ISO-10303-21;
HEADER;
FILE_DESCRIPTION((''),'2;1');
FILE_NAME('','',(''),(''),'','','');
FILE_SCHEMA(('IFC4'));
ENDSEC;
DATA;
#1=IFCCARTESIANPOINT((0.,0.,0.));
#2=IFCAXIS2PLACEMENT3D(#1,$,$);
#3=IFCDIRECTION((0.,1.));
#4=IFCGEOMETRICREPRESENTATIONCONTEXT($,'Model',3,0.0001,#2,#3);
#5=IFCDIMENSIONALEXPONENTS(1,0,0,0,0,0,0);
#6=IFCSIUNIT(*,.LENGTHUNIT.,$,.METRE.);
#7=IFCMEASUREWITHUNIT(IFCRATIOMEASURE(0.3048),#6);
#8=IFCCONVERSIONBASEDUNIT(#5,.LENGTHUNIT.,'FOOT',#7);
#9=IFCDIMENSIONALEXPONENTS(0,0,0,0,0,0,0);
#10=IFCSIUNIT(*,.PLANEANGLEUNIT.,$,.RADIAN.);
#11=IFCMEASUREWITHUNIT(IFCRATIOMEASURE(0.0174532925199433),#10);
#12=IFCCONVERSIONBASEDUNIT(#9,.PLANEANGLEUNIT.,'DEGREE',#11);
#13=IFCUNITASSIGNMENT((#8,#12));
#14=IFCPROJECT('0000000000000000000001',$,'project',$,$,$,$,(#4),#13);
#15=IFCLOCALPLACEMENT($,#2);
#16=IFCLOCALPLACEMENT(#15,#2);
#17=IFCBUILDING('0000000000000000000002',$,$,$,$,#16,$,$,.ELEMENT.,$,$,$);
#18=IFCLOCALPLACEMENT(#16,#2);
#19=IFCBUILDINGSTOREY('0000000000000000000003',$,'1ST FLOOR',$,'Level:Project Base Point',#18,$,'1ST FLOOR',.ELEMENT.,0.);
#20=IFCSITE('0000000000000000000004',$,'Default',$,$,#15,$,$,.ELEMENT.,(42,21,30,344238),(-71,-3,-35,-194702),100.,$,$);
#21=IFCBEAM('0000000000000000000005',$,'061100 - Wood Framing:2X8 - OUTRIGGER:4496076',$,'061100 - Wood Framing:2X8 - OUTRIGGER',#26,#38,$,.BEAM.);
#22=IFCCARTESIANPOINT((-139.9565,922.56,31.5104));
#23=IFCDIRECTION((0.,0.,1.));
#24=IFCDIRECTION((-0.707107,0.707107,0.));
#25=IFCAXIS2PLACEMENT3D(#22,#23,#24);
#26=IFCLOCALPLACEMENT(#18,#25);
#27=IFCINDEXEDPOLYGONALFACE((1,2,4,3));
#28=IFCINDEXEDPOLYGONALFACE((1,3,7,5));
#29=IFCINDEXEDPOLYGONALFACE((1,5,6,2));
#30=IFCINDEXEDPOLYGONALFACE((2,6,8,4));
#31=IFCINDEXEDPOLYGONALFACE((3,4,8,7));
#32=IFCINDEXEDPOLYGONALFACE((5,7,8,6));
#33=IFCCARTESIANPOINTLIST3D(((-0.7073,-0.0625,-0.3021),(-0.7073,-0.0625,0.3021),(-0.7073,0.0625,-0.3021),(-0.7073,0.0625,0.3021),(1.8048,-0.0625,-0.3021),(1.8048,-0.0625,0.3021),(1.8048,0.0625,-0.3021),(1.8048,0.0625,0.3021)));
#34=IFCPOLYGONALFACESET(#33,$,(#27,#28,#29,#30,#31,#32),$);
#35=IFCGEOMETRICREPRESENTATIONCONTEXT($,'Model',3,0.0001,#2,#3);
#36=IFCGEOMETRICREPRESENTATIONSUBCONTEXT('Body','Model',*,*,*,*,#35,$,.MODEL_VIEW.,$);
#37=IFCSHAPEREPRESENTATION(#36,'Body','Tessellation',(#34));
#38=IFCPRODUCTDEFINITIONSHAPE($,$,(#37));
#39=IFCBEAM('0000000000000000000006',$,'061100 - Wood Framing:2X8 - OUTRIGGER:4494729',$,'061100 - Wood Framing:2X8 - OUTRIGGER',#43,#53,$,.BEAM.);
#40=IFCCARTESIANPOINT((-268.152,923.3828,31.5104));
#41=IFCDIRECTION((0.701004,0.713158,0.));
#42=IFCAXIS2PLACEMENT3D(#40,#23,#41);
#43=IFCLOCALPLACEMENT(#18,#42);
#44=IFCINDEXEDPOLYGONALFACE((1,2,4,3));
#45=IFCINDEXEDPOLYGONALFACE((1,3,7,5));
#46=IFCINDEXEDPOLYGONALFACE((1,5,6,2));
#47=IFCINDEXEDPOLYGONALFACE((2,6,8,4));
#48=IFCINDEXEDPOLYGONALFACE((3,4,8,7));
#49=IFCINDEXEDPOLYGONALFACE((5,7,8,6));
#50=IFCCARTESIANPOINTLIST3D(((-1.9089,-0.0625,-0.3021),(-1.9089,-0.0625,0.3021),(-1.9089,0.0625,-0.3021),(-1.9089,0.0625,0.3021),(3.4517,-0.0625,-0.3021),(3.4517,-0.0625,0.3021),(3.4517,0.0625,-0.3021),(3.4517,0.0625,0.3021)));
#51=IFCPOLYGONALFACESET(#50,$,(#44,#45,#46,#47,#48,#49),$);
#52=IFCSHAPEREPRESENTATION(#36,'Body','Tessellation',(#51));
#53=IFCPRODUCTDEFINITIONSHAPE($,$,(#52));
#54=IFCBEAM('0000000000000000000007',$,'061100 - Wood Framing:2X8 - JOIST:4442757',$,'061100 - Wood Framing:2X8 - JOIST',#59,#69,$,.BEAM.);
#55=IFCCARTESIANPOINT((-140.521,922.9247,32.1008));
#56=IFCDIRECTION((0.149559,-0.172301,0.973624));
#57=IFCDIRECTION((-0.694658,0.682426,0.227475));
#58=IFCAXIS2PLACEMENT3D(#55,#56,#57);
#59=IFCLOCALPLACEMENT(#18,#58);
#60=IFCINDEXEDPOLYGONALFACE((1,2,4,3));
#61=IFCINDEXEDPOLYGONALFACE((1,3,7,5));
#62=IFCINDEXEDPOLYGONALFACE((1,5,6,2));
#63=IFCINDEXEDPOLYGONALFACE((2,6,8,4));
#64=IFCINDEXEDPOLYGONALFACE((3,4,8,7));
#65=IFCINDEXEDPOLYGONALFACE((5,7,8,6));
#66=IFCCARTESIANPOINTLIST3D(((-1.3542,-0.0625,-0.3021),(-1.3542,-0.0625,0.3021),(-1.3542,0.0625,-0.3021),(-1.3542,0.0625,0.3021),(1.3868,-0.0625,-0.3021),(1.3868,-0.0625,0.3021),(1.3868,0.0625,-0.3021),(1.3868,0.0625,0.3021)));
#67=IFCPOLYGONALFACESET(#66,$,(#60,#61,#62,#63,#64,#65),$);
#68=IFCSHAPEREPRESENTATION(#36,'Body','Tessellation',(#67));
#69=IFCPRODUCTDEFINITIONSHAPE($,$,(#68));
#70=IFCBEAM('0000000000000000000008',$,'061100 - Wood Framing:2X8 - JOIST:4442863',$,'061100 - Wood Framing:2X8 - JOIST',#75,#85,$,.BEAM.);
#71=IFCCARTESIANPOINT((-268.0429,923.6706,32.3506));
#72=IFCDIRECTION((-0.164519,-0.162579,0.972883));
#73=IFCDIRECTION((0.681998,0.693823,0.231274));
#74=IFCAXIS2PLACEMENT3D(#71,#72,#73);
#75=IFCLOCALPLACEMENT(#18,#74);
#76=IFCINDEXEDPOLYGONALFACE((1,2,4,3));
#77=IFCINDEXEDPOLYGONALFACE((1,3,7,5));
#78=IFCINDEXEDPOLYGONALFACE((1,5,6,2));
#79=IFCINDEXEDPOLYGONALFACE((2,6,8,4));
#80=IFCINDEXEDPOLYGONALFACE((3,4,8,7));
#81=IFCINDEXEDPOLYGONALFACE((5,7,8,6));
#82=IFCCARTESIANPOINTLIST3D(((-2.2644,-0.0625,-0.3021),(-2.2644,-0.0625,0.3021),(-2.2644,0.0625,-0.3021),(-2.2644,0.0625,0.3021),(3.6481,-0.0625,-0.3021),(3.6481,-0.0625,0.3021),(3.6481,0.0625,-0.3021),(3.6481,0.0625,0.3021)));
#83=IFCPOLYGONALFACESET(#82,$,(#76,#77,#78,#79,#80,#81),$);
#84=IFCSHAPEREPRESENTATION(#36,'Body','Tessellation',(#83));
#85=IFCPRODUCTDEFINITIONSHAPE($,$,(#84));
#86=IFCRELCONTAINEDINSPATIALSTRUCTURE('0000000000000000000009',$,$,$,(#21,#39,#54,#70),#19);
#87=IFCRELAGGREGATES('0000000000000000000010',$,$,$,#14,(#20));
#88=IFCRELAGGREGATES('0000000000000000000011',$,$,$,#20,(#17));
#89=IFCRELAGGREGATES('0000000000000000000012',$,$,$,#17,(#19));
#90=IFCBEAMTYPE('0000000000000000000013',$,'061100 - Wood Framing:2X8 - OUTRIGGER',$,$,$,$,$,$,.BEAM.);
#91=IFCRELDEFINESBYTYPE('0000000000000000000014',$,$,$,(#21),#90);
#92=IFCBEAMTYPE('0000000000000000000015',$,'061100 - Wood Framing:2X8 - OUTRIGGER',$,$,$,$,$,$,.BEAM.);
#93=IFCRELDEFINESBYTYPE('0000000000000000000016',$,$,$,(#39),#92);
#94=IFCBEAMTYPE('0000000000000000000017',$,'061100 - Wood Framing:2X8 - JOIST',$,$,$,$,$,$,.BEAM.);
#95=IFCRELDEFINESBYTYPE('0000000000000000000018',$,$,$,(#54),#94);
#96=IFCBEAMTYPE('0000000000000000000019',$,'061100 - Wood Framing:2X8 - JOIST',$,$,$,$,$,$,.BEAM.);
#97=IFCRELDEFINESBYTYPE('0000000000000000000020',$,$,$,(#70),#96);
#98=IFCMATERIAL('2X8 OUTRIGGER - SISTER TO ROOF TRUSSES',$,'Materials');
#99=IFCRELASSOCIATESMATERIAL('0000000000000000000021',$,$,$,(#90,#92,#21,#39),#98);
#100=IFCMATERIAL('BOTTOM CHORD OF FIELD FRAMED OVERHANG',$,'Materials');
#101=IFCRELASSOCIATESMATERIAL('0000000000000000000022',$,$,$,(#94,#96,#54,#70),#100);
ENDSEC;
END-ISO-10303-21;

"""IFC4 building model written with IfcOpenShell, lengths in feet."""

from ifc_helpers import new_model, entity, si_unit, converted_unit, direction, frame, frame_2d, origin, origin_2d_with_axis, place, context, subcontext, project, spatial, rectangle, extrude, source, transform, mapped, material, material_profile, profile_set, profile_usage, type_object, type_shapes, element, save


model = new_model("IFC4")

# Units and contexts
model_context_1 = context("Model", 3, precision=0.0001, world=origin(), true_north=direction((0.0, 1.0)))
model_context_2 = context("Model", 3, precision=0.0001, world=origin(), true_north=direction((0.0, 1.0)))
body_context = subcontext(model_context_2, "Body", "Model", "MODEL_VIEW")
ifc_project = project(units=[converted_unit("LENGTHUNIT", "FOOT", entity("IfcRatioMeasure", 0.3048), si_unit("LENGTHUNIT", "METRE"), dimensions=[1, 0, 0, 0, 0, 0, 0]), converted_unit("PLANEANGLEUNIT", "DEGREE", entity("IfcRatioMeasure", 0.0174532925199433), si_unit("PLANEANGLEUNIT", "RADIAN"), dimensions=[0, 0, 0, 0, 0, 0, 0])], contexts=[model_context_1])

# Site, building, storey
site_placement = place(None, origin())
site = spatial("IfcSite", under=ifc_project, at=site_placement, Name="Default", CompositionType="ELEMENT", RefLatitude=(42, 21, 30, 344238), RefLongitude=(-71, -3, -35, -194702), RefElevation=100.0)
building_placement = place(site_placement, origin())
building = spatial("IfcBuilding", under=site, at=building_placement, CompositionType="ELEMENT")
storey_placement = place(building_placement, origin())
storey = spatial("IfcBuildingStorey", under=building, at=storey_placement, Name="1ST FLOOR", ObjectType="Level:Project Base Point", LongName="1ST FLOOR", CompositionType="ELEMENT", Elevation=0.0)

# Beams
ifc_material_1 = material(Name="2X8 OUTRIGGER - SISTER TO ROOF TRUSSES", Category="Materials")
ifc_material_profile_1 = material_profile(ifc_material_1, rectangle(XDim=0.6042, YDim=0.125, at=origin_2d_with_axis()), Name="2X8 - OUTRIGGER")
ifc_profile_set_1 = profile_set([ifc_material_profile_1], Name="2X8 - OUTRIGGER")
ifc_profile_usage_1 = profile_usage(ifc_profile_set_1, cardinal=8)
beam_type_1 = type_object("IfcBeamType", Name="061100 - Wood Framing:2X8 - OUTRIGGER", PredefinedType="BEAM", material=ifc_profile_set_1)
shared_shape_1 = source(origin(), body_context, "Body", "SweptSolid", [
    extrude(rectangle(XDim=0.6042, YDim=0.125, at=frame_2d((0.0, 0.0), x_axis=(1.0, 0.0))), frame((-0.7073, 0.0, 0.0), z_axis=(1.0, 0.0, 0.0), x_axis=(0.0, 0.0, -1.0)), (0.0, 0.0, 1.0), 2.5121),
])
type_shapes(beam_type_1, [shared_shape_1])
beam_1_placement = place(storey_placement, frame((-139.9565, 922.56, 31.5104), z_axis=(0.0, 0.0, 1.0), x_axis=(-0.707107, 0.707107, 0.0)))
element("IfcBeam", 1, at=beam_1_placement, inside=storey, type_object=beam_type_1, material=ifc_profile_usage_1, Name="061100 - Wood Framing:2X8 - OUTRIGGER:4496076", ObjectType="061100 - Wood Framing:2X8 - OUTRIGGER", PredefinedType="BEAM", context=body_context, shape_type="MappedRepresentation", body=[
    mapped(shared_shape_1, transform((0.0, 0.0, 0.0), scale=1.0)),
])
ifc_profile_usage_2 = profile_usage(ifc_profile_set_1, cardinal=8)
beam_type_2 = type_object("IfcBeamType", Name="061100 - Wood Framing:2X8 - OUTRIGGER", PredefinedType="BEAM", material=ifc_profile_set_1)
shared_shape_2 = source(origin(), body_context, "Body", "SweptSolid", [
    extrude(rectangle(XDim=0.6042, YDim=0.125, at=frame_2d((0.0, 0.0), x_axis=(1.0, 0.0))), frame((-1.9089, 0.0, 0.0), z_axis=(1.0, 0.0, 0.0), x_axis=(0.0, 0.0, -1.0)), (0.0, 0.0, 1.0), 5.3606),
])
type_shapes(beam_type_2, [shared_shape_2])
beam_2_placement = place(storey_placement, frame((-268.152, 923.3828, 31.5104), z_axis=(0.0, 0.0, 1.0), x_axis=(0.701004, 0.713158, 0.0)))
element("IfcBeam", 2, at=beam_2_placement, inside=storey, type_object=beam_type_2, material=ifc_profile_usage_2, Name="061100 - Wood Framing:2X8 - OUTRIGGER:4494729", ObjectType="061100 - Wood Framing:2X8 - OUTRIGGER", PredefinedType="BEAM", context=body_context, shape_type="MappedRepresentation", body=[
    mapped(shared_shape_2, transform((0.0, 0.0, 0.0), scale=1.0)),
])
ifc_material_2 = material(Name="BOTTOM CHORD OF FIELD FRAMED OVERHANG", Category="Materials")
ifc_material_profile_2 = material_profile(ifc_material_2, rectangle(XDim=0.6042, YDim=0.125, at=origin_2d_with_axis()), Name="2X8 - JOIST")
ifc_profile_set_2 = profile_set([ifc_material_profile_2], Name="2X8 - JOIST")
ifc_profile_usage_3 = profile_usage(ifc_profile_set_2, cardinal=8)
beam_type_3 = type_object("IfcBeamType", Name="061100 - Wood Framing:2X8 - JOIST", PredefinedType="BEAM", material=ifc_profile_set_2)
shared_shape_3 = source(origin(), body_context, "Body", "SweptSolid", [
    extrude(rectangle(XDim=0.6042, YDim=0.125, at=frame_2d((0.0, 0.0), x_axis=(1.0, 0.0))), frame((-1.3542, 0.0, 0.0), z_axis=(1.0, 0.0, 0.0), x_axis=(0.0, 0.0, -1.0)), (0.0, 0.0, 1.0), 2.7409),
])
type_shapes(beam_type_3, [shared_shape_3])
beam_3_placement = place(storey_placement, frame((-140.521, 922.9247, 32.1008), z_axis=(0.149559, -0.172301, 0.973624), x_axis=(-0.694658, 0.682426, 0.227475)))
element("IfcBeam", 3, at=beam_3_placement, inside=storey, type_object=beam_type_3, material=ifc_profile_usage_3, Name="061100 - Wood Framing:2X8 - JOIST:4442757", ObjectType="061100 - Wood Framing:2X8 - JOIST", PredefinedType="BEAM", context=body_context, shape_type="MappedRepresentation", body=[
    mapped(shared_shape_3, transform((0.0, 0.0, 0.0), scale=1.0)),
])
ifc_profile_usage_4 = profile_usage(ifc_profile_set_2, cardinal=8)
beam_type_4 = type_object("IfcBeamType", Name="061100 - Wood Framing:2X8 - JOIST", PredefinedType="BEAM", material=ifc_profile_set_2)
shared_shape_4 = source(origin(), body_context, "Body", "SweptSolid", [
    extrude(rectangle(XDim=0.6042, YDim=0.125, at=frame_2d((0.0, 0.0), x_axis=(1.0, 0.0))), frame((-2.2644, 0.0, 0.0), z_axis=(1.0, 0.0, 0.0), x_axis=(0.0, 0.0, -1.0)), (0.0, 0.0, 1.0), 5.9125),
])
type_shapes(beam_type_4, [shared_shape_4])
beam_4_placement = place(storey_placement, frame((-268.0429, 923.6706, 32.3506), z_axis=(-0.164519, -0.162579, 0.972883), x_axis=(0.681998, 0.693823, 0.231274)))
element("IfcBeam", 4, at=beam_4_placement, inside=storey, type_object=beam_type_4, material=ifc_profile_usage_4, Name="061100 - Wood Framing:2X8 - JOIST:4442863", ObjectType="061100 - Wood Framing:2X8 - JOIST", PredefinedType="BEAM", context=body_context, shape_type="MappedRepresentation", body=[
    mapped(shared_shape_4, transform((0.0, 0.0, 0.0), scale=1.0)),
])

save(model, "model.ifc")
